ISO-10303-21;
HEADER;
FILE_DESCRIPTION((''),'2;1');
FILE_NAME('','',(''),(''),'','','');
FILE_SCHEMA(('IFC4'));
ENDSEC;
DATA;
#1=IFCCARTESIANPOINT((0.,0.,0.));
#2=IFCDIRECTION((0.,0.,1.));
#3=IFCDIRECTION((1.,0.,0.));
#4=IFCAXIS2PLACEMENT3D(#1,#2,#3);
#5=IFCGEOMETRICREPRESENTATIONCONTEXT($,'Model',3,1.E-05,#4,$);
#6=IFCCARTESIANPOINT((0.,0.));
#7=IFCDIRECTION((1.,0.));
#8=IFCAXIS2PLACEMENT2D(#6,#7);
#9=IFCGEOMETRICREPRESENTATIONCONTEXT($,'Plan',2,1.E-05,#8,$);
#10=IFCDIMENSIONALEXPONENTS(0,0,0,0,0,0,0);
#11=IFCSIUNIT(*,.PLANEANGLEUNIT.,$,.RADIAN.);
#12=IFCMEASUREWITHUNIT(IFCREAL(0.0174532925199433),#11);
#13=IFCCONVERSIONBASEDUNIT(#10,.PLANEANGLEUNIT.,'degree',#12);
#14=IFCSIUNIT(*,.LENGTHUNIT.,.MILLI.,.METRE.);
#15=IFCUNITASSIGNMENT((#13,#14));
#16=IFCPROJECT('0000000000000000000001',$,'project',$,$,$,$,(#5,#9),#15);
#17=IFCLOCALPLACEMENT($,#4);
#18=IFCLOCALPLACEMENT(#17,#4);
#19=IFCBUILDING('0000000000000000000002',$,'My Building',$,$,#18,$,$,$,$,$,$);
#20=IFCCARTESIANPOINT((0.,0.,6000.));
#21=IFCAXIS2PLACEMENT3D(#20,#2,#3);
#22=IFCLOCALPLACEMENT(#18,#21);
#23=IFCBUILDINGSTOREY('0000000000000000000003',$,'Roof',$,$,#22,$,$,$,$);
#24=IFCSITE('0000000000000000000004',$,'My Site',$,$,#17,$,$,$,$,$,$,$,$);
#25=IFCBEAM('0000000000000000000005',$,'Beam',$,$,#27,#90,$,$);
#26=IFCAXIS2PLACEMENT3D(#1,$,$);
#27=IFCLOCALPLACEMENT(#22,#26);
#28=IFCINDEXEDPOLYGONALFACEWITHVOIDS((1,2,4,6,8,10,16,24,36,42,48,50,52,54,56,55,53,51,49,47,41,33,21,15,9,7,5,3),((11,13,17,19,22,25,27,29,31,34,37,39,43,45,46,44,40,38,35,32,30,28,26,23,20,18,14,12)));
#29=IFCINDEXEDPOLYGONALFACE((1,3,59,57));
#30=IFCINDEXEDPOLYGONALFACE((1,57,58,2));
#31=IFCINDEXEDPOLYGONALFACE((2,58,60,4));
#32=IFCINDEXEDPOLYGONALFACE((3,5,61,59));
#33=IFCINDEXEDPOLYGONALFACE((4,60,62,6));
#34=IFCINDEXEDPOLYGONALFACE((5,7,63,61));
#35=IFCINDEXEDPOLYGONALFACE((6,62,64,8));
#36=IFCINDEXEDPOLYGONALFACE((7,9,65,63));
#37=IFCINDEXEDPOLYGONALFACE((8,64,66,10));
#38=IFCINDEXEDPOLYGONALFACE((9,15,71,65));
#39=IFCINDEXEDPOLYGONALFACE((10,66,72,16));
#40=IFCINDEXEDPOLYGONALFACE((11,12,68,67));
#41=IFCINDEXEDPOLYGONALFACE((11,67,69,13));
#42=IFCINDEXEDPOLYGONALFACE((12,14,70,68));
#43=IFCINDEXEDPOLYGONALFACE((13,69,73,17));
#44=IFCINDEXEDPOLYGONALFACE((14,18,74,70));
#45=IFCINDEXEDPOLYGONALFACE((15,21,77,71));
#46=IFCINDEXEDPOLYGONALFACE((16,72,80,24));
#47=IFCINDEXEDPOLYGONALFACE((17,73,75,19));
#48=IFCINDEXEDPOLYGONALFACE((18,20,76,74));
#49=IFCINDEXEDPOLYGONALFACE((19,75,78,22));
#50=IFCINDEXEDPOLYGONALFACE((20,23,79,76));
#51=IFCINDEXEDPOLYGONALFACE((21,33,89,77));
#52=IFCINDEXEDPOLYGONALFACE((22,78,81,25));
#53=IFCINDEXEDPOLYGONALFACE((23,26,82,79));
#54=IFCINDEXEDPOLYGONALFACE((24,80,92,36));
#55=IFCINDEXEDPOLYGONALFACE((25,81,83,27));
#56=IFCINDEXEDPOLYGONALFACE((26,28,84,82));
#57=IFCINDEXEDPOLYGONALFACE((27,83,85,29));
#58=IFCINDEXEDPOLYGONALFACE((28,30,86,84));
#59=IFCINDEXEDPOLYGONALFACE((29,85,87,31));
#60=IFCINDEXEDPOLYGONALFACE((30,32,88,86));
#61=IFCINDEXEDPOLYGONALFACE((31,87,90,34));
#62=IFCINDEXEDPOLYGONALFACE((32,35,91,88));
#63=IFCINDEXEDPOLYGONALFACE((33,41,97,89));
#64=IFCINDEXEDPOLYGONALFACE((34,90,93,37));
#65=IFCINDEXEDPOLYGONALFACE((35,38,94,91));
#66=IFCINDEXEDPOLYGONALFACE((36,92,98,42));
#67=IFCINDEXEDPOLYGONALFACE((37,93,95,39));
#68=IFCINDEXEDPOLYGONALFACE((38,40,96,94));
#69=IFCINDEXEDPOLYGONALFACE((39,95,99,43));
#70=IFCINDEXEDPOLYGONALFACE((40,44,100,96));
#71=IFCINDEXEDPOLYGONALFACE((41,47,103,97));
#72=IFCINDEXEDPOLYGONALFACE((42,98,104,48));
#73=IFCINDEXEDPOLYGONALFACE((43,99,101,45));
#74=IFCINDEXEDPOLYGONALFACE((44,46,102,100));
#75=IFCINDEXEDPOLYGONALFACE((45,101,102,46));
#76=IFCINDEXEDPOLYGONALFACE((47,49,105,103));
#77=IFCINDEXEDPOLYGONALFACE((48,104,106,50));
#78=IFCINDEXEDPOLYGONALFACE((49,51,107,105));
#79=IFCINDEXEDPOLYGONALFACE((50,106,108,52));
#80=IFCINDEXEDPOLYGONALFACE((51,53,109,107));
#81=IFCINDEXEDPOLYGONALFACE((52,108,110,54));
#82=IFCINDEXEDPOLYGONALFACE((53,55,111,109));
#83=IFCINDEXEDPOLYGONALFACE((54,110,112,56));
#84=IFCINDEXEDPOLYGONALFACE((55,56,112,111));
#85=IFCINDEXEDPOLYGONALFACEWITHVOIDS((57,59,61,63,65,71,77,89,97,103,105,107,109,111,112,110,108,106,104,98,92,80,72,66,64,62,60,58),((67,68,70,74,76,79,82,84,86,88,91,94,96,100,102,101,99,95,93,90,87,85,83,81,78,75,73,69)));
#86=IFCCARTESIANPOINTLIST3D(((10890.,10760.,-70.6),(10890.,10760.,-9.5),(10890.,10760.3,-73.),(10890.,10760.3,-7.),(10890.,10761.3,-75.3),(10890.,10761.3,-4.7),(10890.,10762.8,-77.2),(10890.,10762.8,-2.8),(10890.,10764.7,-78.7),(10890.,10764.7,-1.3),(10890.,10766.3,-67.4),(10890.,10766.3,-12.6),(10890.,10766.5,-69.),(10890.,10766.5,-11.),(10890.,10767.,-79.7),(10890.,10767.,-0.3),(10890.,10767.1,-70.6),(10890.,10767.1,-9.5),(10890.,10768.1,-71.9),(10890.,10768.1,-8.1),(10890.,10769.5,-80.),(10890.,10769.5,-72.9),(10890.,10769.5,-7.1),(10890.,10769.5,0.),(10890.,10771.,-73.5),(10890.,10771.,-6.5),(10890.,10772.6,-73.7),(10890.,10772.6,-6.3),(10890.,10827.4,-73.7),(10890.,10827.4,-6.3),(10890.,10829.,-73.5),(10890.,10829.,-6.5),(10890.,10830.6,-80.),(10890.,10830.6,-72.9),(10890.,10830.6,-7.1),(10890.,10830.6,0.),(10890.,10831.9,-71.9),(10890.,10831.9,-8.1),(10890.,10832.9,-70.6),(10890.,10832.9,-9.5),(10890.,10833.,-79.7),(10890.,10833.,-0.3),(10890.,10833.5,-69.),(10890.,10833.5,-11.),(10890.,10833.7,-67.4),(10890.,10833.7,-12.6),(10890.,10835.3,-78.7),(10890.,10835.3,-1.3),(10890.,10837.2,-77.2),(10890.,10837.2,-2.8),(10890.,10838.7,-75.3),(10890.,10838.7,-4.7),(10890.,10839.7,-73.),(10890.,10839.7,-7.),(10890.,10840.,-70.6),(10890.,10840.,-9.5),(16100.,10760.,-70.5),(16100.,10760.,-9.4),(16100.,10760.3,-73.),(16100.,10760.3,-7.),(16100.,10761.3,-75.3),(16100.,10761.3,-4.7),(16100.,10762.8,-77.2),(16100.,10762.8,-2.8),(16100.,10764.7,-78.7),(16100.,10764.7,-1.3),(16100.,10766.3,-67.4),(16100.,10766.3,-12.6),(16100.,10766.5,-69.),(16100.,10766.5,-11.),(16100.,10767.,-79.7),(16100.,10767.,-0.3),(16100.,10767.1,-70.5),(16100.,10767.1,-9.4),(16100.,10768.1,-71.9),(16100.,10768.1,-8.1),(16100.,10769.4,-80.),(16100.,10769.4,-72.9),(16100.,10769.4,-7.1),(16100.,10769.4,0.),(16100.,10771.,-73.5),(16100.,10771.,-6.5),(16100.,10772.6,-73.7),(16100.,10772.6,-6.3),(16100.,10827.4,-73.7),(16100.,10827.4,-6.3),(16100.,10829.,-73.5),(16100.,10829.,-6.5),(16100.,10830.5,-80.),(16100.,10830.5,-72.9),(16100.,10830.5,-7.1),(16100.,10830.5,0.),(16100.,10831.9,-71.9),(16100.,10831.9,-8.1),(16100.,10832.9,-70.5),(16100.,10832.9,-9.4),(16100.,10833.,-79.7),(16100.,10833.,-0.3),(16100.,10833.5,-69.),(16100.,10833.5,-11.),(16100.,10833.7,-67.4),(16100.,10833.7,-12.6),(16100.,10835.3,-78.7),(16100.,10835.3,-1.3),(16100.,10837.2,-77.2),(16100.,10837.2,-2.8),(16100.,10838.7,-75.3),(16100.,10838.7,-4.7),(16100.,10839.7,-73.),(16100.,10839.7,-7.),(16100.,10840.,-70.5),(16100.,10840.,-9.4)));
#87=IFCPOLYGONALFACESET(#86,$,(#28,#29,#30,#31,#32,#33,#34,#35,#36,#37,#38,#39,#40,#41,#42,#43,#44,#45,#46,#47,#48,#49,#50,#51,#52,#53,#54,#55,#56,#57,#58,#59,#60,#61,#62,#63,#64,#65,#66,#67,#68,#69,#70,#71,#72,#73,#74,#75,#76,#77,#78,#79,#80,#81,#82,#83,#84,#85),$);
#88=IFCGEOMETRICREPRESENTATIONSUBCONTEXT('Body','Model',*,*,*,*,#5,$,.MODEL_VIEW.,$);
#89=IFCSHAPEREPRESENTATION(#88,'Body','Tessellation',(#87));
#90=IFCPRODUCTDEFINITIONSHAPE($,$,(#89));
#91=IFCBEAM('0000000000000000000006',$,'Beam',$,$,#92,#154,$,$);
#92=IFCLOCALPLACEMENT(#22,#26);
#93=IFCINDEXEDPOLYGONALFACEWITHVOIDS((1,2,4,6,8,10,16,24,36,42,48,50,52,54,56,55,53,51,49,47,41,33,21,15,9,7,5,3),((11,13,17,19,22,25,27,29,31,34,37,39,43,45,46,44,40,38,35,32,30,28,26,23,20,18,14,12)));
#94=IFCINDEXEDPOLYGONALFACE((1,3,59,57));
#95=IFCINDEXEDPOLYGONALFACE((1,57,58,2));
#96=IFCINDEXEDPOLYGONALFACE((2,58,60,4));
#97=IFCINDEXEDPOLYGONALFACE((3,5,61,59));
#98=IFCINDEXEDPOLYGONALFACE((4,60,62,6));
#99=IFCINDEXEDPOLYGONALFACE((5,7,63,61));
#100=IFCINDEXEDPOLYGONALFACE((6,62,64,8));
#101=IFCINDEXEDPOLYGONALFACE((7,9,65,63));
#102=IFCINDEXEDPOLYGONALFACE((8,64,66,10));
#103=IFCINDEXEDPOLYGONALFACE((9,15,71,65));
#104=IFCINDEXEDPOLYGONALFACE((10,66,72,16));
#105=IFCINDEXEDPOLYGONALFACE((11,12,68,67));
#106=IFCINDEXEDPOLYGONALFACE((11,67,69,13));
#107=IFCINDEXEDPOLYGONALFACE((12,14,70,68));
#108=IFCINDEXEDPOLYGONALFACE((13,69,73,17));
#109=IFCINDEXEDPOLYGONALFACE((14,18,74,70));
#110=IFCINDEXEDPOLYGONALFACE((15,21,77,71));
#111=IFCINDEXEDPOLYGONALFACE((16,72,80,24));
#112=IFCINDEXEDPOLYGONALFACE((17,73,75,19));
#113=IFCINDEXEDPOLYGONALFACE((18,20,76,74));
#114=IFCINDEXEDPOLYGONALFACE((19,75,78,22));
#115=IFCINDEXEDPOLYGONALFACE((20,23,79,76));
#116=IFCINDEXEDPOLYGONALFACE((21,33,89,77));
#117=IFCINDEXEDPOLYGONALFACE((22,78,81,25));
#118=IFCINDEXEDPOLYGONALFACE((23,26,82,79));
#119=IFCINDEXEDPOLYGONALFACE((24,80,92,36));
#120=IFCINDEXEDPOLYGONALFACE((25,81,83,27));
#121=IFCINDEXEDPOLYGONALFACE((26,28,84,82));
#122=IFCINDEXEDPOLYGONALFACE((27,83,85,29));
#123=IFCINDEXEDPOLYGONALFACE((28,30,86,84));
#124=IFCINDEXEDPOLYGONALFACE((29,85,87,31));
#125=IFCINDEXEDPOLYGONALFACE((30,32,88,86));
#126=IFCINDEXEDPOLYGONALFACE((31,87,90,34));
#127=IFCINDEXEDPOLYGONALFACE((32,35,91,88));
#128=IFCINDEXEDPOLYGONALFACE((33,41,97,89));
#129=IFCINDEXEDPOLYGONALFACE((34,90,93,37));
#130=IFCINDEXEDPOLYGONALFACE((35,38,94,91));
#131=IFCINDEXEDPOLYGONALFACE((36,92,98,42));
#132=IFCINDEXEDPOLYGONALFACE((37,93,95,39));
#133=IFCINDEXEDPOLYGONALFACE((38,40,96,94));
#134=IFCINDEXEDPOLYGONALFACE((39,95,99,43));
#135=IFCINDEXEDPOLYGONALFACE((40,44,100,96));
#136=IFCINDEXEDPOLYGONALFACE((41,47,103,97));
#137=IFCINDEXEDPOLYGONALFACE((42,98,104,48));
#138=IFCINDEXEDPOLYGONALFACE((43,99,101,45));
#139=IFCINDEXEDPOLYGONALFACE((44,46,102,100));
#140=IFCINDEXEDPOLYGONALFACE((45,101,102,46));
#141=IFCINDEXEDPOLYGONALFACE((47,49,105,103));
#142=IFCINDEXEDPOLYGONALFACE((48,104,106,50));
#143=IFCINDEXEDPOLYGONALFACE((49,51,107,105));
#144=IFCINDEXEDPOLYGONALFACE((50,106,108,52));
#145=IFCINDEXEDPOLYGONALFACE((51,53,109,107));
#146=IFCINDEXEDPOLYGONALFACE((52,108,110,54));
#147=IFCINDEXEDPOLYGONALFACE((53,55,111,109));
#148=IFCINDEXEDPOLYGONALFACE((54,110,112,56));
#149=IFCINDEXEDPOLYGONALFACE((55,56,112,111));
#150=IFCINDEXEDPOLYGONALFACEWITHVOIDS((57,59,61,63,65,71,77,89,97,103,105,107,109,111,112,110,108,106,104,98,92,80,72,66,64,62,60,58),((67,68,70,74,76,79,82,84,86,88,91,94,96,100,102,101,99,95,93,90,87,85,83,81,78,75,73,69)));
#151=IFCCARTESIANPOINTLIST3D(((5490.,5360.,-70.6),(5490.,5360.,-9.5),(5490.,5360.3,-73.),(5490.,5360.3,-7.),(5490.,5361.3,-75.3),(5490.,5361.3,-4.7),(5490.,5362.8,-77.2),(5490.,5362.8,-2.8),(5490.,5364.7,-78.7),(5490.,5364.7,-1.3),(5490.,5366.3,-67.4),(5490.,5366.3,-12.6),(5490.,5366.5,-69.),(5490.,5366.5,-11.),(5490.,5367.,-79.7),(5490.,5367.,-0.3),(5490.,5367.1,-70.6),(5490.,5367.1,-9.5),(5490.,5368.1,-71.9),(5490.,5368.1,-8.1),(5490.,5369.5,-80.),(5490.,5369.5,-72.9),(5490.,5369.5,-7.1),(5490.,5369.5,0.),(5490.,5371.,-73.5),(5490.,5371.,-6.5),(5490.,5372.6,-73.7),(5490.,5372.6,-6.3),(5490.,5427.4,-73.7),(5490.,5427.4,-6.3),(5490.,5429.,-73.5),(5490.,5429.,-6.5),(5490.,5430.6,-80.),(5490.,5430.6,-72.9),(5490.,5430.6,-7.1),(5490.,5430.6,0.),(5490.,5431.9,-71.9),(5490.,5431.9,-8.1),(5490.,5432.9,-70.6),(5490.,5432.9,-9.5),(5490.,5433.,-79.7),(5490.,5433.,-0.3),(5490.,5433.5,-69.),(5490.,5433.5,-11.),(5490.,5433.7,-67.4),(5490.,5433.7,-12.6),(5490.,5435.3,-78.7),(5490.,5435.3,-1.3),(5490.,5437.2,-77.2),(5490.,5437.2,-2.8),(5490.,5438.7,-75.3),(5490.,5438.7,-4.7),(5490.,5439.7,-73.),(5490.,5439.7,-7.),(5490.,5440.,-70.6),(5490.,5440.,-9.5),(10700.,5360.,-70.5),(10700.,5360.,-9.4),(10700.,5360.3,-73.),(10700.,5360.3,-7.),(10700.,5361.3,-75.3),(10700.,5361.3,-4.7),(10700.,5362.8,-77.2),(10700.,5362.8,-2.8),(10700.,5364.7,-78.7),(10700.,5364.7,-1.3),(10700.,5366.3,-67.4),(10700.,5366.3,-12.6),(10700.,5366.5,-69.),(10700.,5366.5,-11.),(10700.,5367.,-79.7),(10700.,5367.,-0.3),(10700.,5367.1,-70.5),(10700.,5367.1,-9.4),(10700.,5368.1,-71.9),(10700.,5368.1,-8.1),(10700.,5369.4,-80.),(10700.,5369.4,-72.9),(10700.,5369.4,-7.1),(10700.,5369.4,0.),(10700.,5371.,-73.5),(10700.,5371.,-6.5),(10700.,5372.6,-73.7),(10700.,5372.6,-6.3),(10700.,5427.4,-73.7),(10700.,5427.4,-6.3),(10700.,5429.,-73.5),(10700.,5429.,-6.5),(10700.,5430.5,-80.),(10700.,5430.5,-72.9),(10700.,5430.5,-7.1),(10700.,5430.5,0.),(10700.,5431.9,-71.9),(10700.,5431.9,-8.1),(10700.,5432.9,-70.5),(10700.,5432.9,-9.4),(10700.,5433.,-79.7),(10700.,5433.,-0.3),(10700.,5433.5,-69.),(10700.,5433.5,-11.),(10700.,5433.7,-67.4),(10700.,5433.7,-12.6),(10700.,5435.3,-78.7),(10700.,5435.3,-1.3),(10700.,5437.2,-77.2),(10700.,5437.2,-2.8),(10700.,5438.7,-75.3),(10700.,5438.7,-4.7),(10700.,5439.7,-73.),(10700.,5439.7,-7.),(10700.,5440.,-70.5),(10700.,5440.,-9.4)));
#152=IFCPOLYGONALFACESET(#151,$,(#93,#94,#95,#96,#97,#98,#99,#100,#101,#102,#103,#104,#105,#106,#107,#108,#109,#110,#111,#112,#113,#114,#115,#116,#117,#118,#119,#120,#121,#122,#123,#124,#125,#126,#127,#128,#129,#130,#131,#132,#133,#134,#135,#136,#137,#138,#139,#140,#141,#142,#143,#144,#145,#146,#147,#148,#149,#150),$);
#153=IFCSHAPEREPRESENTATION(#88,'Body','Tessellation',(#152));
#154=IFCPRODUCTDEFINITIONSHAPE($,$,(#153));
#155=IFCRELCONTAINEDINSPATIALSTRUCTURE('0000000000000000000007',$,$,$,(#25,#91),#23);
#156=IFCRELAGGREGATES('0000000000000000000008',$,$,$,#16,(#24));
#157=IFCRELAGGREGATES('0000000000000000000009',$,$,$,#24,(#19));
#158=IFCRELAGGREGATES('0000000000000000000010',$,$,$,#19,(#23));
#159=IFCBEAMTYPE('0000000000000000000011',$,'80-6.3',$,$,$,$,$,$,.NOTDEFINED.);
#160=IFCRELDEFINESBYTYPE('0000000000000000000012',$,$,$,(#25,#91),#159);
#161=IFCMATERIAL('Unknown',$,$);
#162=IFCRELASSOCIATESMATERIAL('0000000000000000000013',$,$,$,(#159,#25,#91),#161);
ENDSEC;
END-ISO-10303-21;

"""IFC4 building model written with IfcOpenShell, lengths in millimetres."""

from ifc_helpers import new_model, entity, si_unit, converted_unit, frame, origin_with_axes, origin_2d_with_axis, place, context, subcontext, project, spatial, hollow_rectangle, extrude, material, material_profile, profile_set, profile_usage, type_object, element, save


model = new_model("IFC4")

# Units and contexts
model_context = context("Model", 3, precision=1e-05, world=origin_with_axes())
plan_context = context("Plan", 2, precision=1e-05, world=origin_2d_with_axis())
body_context = subcontext(model_context, "Body", "Model", "MODEL_VIEW")
ifc_project = project(units=[converted_unit("PLANEANGLEUNIT", "degree", entity("IfcReal", 0.0174532925199433), si_unit("PLANEANGLEUNIT", "RADIAN"), dimensions=[0, 0, 0, 0, 0, 0, 0]), si_unit("LENGTHUNIT", "METRE", prefix="MILLI")], contexts=[model_context, plan_context])

# Site, building, storey
site_placement = place(None, origin_with_axes())
site = spatial("IfcSite", under=ifc_project, at=site_placement, Name="My Site")
building_placement = place(site_placement, origin_with_axes())
building = spatial("IfcBuilding", under=site, at=building_placement, Name="My Building")
storey_placement = place(building_placement, frame((0.0, 0.0, 6000.0), z_axis=(0.0, 0.0, 1.0), x_axis=(1.0, 0.0, 0.0)))
storey = spatial("IfcBuildingStorey", under=building, at=storey_placement, Name="Roof")

# Beams
ifc_material = material(Name="Unknown")
ifc_material_profile_1 = material_profile(ifc_material, hollow_rectangle(XDim=80.0, YDim=80.0, WallThickness=6.3, InnerFilletRadius=6.3, OuterFilletRadius=9.4))
ifc_profile_set_1 = profile_set([ifc_material_profile_1])
beam_type_1 = type_object("IfcBeamType", Name="80-6.3", PredefinedType="NOTDEFINED", material=ifc_profile_set_1)
ifc_profile_usage_1 = profile_usage(ifc_profile_set_1, cardinal=8)
beam_1_placement = place(storey_placement, frame((10890.0, 10800.0, 0.0), z_axis=(1.0, 0.0, 0.0), x_axis=(0.0, 1.0, 0.0)))
element("IfcBeam", 1, at=beam_1_placement, inside=storey, type_object=beam_type_1, material=ifc_profile_usage_1, Name="Beam", context=body_context, shape_type="SweptSolid", body=[
    extrude(hollow_rectangle(XDim=80.0, YDim=80.0, WallThickness=6.3, InnerFilletRadius=6.3, OuterFilletRadius=9.4), frame((0.0, -40.0, 0.0), z_axis=(0.0, 0.0, 1.0), x_axis=(1.0, 0.0, 0.0)), (0.0, 0.0, 1.0), 5210.0),
])
ifc_profile_usage_2 = profile_usage(ifc_profile_set_1, cardinal=8)
beam_2_placement = place(storey_placement, frame((5490.0, 5400.0, 0.0), z_axis=(1.0, 0.0, 0.0), x_axis=(0.0, 1.0, 0.0)))
element("IfcBeam", 2, at=beam_2_placement, inside=storey, type_object=beam_type_1, material=ifc_profile_usage_2, Name="Beam", context=body_context, shape_type="SweptSolid", body=[
    extrude(hollow_rectangle(XDim=80.0, YDim=80.0, WallThickness=6.3, InnerFilletRadius=6.3, OuterFilletRadius=9.4), frame((0.0, -40.0, 0.0), z_axis=(0.0, 0.0, 1.0), x_axis=(1.0, 0.0, 0.0)), (0.0, 0.0, 1.0), 5210.0),
])

save(model, "model.ifc")
